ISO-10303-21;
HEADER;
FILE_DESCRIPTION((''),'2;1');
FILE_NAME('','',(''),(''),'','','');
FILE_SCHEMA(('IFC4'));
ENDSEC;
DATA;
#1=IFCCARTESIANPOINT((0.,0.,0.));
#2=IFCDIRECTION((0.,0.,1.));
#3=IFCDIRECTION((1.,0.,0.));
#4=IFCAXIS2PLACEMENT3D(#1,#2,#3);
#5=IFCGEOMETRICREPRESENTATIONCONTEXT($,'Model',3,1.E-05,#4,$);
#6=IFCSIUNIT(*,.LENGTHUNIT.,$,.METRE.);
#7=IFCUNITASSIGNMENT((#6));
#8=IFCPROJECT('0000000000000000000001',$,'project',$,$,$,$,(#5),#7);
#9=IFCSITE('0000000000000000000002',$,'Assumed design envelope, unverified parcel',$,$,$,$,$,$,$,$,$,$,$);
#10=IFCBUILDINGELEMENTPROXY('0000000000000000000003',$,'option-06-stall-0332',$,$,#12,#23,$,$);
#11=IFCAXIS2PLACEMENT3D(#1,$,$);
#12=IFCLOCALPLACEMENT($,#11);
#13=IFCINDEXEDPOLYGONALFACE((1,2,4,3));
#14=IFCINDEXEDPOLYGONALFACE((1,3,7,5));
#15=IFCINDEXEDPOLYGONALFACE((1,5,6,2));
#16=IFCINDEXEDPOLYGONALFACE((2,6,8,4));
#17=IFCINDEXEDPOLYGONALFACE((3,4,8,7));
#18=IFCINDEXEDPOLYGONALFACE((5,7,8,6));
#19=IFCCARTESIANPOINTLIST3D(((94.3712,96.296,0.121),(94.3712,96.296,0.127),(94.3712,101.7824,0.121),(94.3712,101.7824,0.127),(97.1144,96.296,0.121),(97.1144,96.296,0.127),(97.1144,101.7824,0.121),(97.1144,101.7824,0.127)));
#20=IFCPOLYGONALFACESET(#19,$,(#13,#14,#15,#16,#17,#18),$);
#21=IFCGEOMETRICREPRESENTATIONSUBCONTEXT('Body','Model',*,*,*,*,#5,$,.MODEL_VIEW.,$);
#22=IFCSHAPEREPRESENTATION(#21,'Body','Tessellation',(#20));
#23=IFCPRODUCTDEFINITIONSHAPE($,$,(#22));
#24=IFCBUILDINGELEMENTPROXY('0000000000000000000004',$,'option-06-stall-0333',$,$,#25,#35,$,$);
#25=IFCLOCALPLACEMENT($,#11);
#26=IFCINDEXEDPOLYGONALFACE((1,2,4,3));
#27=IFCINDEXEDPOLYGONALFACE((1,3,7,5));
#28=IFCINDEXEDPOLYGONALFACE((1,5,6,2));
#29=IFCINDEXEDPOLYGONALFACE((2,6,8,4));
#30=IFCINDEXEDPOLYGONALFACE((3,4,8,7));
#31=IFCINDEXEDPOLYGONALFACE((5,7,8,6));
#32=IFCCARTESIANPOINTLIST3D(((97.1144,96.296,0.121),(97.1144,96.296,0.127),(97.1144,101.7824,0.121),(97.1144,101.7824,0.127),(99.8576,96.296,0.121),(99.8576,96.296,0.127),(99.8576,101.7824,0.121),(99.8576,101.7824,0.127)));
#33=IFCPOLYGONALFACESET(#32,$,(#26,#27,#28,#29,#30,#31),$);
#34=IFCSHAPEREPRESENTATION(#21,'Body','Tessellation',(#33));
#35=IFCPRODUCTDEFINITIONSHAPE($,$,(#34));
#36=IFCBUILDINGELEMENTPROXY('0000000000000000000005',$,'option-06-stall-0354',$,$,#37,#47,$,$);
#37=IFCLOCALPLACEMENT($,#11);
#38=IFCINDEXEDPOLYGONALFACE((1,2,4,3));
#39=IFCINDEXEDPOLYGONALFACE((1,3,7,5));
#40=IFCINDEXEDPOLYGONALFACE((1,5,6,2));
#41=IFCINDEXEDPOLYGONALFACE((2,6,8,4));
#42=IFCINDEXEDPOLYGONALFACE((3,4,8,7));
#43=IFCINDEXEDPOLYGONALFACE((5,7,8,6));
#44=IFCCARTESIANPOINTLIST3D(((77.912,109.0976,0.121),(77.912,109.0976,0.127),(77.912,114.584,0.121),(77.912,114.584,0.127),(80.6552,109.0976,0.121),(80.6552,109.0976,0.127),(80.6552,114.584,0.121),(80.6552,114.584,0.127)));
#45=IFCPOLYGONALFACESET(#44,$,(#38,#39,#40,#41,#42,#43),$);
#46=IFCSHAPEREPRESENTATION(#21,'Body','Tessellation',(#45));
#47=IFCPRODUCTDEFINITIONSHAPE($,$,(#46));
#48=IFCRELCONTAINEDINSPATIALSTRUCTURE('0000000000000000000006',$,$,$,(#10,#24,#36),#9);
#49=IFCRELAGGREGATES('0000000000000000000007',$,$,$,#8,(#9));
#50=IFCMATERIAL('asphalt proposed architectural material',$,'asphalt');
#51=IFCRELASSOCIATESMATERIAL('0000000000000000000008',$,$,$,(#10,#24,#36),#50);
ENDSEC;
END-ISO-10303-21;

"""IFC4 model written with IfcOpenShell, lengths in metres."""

from ifc_helpers import new_model, si_unit, frame, origin_with_axes, place, context, subcontext, project, spatial, rectangle, extrude, material, element, save


model = new_model("IFC4")

# Units and contexts
model_context = context("Model", 3, precision=1e-05, world=origin_with_axes())
body_context = subcontext(model_context, "Body", "Model", "MODEL_VIEW")
ifc_project = project(units=[si_unit("LENGTHUNIT", "METRE")], contexts=[model_context])

# Site
site = spatial("IfcSite", under=ifc_project, Name="Assumed design envelope, unverified parcel")

# Building element proxies
ifc_material = material(Name="asphalt proposed architectural material", Category="asphalt")
for number, where, z_axis, x_axis, name in (
    (1, (95.7428, 99.0392, 0.121), (0.0, 0.0, 1.0), (1.0, 0.0, 0.0), "option-06-stall-0332"),
    (2, (98.486, 99.0392, 0.121), (0.0, 0.0, 1.0), (1.0, 0.0, 0.0), "option-06-stall-0333"),
    (3, (79.2836, 111.8408, 0.121), (0.0, 0.0, 1.0), (1.0, 0.0, 0.0), "option-06-stall-0354"),
):
    element("IfcBuildingElementProxy", number, at=place(None, frame(where, z_axis=z_axis, x_axis=x_axis)), inside=site, material=ifc_material, Name=name, context=body_context, shape_type="SweptSolid", body=[
        extrude(rectangle(XDim=2.7432, YDim=5.4864), origin_with_axes(), (0.0, 0.0, 1.0), 0.006),
    ])

save(model, "model.ifc")
